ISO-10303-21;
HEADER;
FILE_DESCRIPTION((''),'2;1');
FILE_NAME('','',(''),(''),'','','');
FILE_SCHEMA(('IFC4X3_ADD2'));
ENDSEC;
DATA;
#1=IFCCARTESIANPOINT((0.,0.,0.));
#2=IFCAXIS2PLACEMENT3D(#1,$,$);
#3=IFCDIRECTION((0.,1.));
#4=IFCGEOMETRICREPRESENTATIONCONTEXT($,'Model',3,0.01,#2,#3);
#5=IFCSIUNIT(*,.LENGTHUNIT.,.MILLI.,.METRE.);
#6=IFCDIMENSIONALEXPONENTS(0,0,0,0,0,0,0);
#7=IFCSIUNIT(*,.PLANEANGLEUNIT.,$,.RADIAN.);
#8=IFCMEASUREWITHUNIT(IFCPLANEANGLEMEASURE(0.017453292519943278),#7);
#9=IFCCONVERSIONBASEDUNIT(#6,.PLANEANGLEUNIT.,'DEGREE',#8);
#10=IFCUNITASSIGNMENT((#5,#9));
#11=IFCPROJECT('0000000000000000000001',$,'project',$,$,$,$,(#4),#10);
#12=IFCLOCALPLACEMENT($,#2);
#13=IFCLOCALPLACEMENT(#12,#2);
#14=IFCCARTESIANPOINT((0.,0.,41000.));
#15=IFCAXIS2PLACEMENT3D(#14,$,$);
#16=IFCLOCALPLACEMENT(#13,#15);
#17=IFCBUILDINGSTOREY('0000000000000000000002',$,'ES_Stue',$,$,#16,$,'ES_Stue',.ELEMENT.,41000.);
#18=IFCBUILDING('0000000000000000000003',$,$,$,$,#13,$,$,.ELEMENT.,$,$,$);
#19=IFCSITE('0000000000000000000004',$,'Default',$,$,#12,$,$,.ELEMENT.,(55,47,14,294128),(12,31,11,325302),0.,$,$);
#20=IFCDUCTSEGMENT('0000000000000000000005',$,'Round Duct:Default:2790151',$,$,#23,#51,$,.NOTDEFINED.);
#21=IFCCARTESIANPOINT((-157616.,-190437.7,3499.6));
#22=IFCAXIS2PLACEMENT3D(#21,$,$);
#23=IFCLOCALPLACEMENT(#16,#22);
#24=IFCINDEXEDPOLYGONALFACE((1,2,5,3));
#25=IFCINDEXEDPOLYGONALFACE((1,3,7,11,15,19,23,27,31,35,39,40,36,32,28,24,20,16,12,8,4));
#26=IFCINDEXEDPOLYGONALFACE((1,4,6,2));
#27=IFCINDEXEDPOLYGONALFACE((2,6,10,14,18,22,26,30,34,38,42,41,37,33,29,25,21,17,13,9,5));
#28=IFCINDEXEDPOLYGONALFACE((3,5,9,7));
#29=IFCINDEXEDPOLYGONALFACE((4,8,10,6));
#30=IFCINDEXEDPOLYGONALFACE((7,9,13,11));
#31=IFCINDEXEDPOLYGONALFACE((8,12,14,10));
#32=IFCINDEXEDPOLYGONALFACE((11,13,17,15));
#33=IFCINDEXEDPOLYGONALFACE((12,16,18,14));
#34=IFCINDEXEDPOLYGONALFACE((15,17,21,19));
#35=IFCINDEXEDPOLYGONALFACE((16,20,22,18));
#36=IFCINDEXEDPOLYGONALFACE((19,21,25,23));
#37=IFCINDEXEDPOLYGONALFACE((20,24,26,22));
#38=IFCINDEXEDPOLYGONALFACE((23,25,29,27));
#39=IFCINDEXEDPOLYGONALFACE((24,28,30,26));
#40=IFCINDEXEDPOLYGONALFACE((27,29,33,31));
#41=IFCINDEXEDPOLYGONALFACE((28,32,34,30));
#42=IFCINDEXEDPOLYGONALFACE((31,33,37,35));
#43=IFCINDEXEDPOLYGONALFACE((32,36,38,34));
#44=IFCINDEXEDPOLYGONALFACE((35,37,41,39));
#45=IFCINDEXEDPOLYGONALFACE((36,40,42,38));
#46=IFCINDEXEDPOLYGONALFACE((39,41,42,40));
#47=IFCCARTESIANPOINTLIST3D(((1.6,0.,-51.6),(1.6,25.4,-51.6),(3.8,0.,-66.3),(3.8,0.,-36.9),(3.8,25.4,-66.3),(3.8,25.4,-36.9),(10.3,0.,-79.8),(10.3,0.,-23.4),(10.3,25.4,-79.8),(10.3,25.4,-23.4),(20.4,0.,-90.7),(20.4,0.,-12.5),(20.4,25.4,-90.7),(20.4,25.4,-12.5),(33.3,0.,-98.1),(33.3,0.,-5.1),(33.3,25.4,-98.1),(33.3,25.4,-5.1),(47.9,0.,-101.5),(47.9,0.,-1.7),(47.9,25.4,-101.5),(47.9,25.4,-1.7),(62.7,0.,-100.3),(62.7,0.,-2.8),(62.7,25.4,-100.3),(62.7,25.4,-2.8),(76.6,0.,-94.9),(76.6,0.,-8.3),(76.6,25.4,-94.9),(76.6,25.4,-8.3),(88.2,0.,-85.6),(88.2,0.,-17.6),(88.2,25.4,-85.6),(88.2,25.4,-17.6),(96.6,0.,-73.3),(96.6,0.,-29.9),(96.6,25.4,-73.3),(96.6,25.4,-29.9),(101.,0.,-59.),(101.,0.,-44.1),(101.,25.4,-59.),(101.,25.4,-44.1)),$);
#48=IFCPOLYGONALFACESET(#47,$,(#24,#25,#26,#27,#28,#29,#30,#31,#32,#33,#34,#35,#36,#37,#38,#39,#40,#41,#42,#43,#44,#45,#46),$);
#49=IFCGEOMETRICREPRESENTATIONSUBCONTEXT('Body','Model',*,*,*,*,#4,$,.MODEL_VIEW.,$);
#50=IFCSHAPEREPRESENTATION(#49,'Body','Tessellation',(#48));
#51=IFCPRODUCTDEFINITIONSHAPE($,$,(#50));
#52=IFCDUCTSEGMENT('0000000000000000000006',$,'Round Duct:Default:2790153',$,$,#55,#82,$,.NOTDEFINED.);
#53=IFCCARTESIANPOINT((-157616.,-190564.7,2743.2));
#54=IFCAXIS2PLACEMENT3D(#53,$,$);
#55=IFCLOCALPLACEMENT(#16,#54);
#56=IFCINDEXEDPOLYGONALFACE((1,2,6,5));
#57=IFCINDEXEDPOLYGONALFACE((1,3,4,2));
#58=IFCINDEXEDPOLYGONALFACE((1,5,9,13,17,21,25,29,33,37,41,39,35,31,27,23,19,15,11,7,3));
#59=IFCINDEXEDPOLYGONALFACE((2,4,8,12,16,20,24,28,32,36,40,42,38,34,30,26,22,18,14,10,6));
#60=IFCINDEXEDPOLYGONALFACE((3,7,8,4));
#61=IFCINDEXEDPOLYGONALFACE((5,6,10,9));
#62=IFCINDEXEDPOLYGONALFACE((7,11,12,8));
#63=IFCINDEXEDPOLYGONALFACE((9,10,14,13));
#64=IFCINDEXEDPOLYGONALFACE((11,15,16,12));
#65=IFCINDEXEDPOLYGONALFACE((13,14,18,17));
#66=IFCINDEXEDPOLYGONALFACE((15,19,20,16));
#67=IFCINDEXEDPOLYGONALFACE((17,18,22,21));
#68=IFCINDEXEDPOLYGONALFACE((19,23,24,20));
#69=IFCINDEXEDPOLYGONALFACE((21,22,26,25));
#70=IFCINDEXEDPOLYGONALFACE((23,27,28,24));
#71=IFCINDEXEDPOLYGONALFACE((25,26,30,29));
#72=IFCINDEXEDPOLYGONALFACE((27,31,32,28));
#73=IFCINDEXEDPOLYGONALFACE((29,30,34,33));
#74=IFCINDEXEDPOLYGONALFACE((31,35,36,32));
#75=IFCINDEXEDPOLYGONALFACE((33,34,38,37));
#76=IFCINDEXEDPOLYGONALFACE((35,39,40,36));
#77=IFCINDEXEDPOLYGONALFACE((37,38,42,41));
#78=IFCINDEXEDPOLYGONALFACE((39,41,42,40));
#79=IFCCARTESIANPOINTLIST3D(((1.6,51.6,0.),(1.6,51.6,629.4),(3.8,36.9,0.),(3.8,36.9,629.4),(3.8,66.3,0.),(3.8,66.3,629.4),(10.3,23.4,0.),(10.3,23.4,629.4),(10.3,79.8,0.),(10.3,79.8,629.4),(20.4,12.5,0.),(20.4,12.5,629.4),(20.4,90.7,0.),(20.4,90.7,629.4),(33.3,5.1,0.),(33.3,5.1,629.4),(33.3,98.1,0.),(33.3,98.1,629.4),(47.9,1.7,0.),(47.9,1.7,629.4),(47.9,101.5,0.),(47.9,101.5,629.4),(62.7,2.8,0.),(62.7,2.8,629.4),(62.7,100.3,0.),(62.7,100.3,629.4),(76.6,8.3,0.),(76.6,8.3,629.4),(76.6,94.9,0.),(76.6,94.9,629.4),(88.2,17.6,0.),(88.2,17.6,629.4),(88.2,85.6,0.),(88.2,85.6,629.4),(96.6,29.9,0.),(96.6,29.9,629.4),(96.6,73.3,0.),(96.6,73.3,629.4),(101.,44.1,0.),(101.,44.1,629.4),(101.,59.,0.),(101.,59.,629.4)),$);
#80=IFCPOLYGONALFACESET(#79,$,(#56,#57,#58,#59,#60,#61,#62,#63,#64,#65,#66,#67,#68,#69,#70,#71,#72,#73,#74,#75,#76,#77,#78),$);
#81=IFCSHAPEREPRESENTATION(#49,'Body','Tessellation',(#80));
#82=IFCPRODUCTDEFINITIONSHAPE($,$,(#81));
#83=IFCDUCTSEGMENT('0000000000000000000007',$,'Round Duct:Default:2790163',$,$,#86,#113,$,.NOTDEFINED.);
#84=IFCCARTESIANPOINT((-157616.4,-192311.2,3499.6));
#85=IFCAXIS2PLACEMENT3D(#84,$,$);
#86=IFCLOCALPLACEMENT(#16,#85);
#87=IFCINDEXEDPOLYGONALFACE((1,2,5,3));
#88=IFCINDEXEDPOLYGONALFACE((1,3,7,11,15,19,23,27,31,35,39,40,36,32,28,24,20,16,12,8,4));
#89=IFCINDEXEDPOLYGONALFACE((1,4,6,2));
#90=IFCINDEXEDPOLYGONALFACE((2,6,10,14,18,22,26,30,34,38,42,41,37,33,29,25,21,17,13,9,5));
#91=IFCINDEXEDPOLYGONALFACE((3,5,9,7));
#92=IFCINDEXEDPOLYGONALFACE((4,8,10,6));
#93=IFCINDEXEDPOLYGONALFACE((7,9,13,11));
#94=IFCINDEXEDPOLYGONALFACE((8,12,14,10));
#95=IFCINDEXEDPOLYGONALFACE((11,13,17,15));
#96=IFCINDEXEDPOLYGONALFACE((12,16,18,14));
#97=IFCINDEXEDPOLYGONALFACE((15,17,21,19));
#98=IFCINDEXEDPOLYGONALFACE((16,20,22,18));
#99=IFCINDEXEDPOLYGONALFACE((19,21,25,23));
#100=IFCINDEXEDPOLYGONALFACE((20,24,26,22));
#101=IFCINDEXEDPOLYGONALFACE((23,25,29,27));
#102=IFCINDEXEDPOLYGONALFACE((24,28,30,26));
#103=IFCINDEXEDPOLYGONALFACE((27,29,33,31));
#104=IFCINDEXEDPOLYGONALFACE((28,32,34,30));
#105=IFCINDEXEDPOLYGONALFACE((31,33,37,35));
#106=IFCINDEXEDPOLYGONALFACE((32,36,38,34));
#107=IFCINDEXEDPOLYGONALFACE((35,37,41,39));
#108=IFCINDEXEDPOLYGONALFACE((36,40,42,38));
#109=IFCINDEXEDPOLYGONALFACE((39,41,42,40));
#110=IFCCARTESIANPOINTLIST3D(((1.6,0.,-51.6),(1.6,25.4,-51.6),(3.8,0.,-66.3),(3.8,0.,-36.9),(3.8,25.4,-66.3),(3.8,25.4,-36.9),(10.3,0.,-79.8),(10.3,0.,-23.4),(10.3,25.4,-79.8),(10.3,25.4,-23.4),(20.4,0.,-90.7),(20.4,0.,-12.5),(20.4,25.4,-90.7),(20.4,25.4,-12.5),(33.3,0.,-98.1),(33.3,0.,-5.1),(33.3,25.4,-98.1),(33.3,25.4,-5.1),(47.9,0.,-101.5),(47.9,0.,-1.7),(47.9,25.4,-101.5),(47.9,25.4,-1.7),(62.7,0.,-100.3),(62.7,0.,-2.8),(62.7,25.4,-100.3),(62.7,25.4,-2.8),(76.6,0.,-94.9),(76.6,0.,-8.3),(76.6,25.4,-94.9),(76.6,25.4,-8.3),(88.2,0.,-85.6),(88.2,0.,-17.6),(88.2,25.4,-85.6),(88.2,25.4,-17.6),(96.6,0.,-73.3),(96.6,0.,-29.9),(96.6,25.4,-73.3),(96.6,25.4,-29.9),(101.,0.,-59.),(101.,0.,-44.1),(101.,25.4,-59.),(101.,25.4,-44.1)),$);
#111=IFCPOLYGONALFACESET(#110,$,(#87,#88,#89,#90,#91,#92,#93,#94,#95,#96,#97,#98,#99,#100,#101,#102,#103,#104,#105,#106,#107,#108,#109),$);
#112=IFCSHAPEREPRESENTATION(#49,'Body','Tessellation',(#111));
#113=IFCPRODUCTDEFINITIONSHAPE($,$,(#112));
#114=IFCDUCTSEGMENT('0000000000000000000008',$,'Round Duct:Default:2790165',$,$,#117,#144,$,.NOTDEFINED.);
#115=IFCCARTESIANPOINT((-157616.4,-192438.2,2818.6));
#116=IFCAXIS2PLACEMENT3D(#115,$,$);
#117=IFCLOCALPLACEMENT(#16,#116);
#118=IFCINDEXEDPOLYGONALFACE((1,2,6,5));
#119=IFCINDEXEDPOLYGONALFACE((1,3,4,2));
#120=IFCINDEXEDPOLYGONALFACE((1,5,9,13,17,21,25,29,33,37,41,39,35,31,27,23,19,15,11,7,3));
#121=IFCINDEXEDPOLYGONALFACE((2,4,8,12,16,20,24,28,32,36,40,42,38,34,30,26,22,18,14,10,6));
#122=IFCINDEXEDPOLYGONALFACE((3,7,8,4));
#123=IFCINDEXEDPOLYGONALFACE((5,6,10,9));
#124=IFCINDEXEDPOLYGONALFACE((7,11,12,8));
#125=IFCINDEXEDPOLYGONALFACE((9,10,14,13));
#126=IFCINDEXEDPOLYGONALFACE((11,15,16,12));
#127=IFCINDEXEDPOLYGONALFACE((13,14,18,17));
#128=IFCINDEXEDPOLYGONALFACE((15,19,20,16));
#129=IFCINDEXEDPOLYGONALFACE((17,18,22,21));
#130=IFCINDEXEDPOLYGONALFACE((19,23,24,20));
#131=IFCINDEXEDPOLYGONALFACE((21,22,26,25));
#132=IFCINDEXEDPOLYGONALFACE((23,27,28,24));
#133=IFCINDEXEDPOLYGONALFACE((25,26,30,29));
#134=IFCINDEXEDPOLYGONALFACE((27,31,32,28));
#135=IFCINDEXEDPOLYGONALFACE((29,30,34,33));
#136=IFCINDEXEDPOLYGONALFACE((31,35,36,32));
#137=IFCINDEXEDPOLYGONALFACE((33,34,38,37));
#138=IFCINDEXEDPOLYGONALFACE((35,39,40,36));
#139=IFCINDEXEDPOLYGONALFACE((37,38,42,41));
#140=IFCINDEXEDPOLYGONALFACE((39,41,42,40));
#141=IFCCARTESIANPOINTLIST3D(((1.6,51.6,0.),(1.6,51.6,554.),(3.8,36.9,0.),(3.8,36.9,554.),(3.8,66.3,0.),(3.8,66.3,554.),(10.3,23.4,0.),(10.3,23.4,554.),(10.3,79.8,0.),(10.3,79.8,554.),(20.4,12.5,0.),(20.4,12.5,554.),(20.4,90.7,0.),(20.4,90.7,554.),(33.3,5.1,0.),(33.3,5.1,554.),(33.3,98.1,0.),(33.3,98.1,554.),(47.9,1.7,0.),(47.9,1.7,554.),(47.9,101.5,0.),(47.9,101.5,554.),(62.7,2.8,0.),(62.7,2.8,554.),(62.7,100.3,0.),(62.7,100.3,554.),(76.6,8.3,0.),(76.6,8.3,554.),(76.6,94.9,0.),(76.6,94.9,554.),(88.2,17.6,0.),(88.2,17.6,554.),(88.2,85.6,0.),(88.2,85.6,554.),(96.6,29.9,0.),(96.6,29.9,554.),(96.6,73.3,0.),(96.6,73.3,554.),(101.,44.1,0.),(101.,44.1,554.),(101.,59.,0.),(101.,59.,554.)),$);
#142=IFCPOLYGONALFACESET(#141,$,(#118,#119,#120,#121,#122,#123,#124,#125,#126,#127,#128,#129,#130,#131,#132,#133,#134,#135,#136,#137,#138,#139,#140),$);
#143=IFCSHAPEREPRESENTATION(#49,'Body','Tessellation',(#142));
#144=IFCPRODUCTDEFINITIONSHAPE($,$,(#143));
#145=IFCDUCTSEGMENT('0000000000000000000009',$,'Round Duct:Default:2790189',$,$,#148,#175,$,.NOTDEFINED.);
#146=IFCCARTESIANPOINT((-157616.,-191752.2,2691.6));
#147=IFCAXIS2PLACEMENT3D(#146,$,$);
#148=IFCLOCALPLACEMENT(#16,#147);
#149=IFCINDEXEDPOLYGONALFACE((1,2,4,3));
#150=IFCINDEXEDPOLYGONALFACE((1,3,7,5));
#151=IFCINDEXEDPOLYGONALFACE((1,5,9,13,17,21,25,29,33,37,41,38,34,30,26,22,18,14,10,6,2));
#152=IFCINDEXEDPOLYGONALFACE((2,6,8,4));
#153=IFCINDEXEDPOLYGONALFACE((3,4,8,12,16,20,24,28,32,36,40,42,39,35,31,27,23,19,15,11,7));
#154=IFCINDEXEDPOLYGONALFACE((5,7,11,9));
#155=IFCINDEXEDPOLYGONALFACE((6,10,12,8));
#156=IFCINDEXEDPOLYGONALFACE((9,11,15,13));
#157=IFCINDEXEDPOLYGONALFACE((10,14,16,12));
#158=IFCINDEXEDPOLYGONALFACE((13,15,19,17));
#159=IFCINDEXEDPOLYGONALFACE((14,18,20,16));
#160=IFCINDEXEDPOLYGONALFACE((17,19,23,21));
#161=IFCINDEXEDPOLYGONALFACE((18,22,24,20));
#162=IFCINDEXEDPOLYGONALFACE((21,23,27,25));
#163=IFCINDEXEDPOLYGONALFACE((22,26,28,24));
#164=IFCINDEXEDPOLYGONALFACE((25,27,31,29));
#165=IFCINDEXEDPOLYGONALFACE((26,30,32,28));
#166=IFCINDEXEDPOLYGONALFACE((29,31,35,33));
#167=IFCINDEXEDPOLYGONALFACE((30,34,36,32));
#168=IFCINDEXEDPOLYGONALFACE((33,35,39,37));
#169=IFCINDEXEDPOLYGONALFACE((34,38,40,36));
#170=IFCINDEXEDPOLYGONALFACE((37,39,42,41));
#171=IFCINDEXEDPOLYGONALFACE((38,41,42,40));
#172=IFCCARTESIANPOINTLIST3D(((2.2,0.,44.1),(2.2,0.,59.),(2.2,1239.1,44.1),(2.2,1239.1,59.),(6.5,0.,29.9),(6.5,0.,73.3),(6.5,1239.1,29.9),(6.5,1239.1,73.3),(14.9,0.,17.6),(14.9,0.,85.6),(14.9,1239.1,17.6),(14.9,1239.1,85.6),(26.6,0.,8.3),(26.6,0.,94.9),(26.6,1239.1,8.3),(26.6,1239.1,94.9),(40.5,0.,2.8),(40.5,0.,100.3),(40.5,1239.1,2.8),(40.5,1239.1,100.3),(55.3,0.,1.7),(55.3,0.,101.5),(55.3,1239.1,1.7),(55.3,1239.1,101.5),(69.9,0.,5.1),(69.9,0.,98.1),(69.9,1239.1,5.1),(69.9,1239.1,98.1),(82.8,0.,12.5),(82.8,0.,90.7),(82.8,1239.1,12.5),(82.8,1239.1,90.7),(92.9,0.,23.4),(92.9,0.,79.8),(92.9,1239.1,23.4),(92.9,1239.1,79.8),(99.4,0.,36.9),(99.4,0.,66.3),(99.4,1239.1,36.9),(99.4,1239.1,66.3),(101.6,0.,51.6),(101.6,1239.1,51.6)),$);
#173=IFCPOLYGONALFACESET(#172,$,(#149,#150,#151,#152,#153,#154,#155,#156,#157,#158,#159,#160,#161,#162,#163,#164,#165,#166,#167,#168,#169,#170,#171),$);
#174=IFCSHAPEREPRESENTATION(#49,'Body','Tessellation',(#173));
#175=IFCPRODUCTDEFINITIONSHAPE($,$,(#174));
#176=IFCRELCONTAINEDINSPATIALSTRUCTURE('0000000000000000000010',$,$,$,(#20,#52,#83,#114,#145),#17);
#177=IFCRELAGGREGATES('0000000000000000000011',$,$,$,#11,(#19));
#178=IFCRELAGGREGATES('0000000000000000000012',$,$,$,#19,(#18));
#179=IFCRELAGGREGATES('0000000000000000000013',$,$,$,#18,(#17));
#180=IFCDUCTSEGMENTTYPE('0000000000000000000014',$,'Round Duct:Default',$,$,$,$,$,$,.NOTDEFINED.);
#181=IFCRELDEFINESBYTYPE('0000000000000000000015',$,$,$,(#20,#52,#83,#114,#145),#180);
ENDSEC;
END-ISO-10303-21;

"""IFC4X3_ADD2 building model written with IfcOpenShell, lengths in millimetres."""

from ifc_helpers import new_model, entity, si_unit, converted_unit, direction, frame, origin, origin_2d_with_axis, place, context, subcontext, project, spatial, circle, extrude, type_object, element, save


model = new_model("IFC4X3_ADD2")

# Units and contexts
model_context = context("Model", 3, precision=0.01, world=origin(), true_north=direction((0.0, 1.0)))
body_context = subcontext(model_context, "Body", "Model", "MODEL_VIEW")
ifc_project = project(units=[si_unit("LENGTHUNIT", "METRE", prefix="MILLI"), converted_unit("PLANEANGLEUNIT", "DEGREE", entity("IfcPlaneAngleMeasure", 0.017453292519943278), si_unit("PLANEANGLEUNIT", "RADIAN"), dimensions=[0, 0, 0, 0, 0, 0, 0])], contexts=[model_context])

# Site, building, storey
site_placement = place(None, origin())
site = spatial("IfcSite", under=ifc_project, at=site_placement, Name="Default", CompositionType="ELEMENT", RefLatitude=(55, 47, 14, 294128), RefLongitude=(12, 31, 11, 325302), RefElevation=0.0)
building_placement = place(site_placement, origin())
building = spatial("IfcBuilding", under=site, at=building_placement, CompositionType="ELEMENT")
storey_placement = place(building_placement, frame((0.0, 0.0, 41000.0)))
storey = spatial("IfcBuildingStorey", under=building, at=storey_placement, Name="ES_Stue", LongName="ES_Stue", CompositionType="ELEMENT", Elevation=41000.0)

# Duct segments
duct_segment_type = type_object("IfcDuctSegmentType", Name="Round Duct:Default", PredefinedType="NOTDEFINED")
duct_segment_1_placement = place(storey_placement, frame((-157616.0, -190437.7, 3499.6)))
element("IfcDuctSegment", 1, at=duct_segment_1_placement, inside=storey, type_object=duct_segment_type, Name="Round Duct:Default:2790151", PredefinedType="NOTDEFINED", context=body_context, shape_type="SweptSolid", body=[
    extrude(circle(Radius=50.0, at=origin_2d_with_axis()), frame((51.6, 0.0, -51.6), z_axis=(0.0, 1.0, 0.0), x_axis=(-1.0, 0.0, 0.0)), (0.0, 0.0, 1.0), 25.4),
])
duct_segment_2_placement = place(storey_placement, frame((-157616.0, -190564.7, 2743.2)))
element("IfcDuctSegment", 2, at=duct_segment_2_placement, inside=storey, type_object=duct_segment_type, Name="Round Duct:Default:2790153", PredefinedType="NOTDEFINED", context=body_context, shape_type="SweptSolid", body=[
    extrude(circle(Radius=50.0, at=origin_2d_with_axis()), frame((51.6, 51.6, 0.0), z_axis=(0.0, 0.0, 1.0), x_axis=(-1.0, 0.0, 0.0)), (0.0, 0.0, 1.0), 629.4),
])
duct_segment_3_placement = place(storey_placement, frame((-157616.4, -192311.2, 3499.6)))
element("IfcDuctSegment", 3, at=duct_segment_3_placement, inside=storey, type_object=duct_segment_type, Name="Round Duct:Default:2790163", PredefinedType="NOTDEFINED", context=body_context, shape_type="SweptSolid", body=[
    extrude(circle(Radius=50.0, at=origin_2d_with_axis()), frame((51.6, 0.0, -51.6), z_axis=(0.0, 1.0, 0.0), x_axis=(-1.0, 0.0, 0.0)), (0.0, 0.0, 1.0), 25.4),
])
duct_segment_4_placement = place(storey_placement, frame((-157616.4, -192438.2, 2818.6)))
element("IfcDuctSegment", 4, at=duct_segment_4_placement, inside=storey, type_object=duct_segment_type, Name="Round Duct:Default:2790165", PredefinedType="NOTDEFINED", context=body_context, shape_type="SweptSolid", body=[
    extrude(circle(Radius=50.0, at=origin_2d_with_axis()), frame((51.6, 51.6, 0.0), z_axis=(0.0, 0.0, 1.0), x_axis=(-1.0, 0.0, 0.0)), (0.0, 0.0, 1.0), 554.0),
])
duct_segment_5_placement = place(storey_placement, frame((-157616.0, -191752.2, 2691.6)))
element("IfcDuctSegment", 5, at=duct_segment_5_placement, inside=storey, type_object=duct_segment_type, Name="Round Duct:Default:2790189", PredefinedType="NOTDEFINED", context=body_context, shape_type="SweptSolid", body=[
    extrude(circle(Radius=50.0, at=origin_2d_with_axis()), frame((51.6, 0.0, 51.6), z_axis=(0.0, 1.0, 0.0), x_axis=(1.0, 0.0, 0.0)), (0.0, 0.0, 1.0), 1239.1),
])

save(model, "model.ifc")
